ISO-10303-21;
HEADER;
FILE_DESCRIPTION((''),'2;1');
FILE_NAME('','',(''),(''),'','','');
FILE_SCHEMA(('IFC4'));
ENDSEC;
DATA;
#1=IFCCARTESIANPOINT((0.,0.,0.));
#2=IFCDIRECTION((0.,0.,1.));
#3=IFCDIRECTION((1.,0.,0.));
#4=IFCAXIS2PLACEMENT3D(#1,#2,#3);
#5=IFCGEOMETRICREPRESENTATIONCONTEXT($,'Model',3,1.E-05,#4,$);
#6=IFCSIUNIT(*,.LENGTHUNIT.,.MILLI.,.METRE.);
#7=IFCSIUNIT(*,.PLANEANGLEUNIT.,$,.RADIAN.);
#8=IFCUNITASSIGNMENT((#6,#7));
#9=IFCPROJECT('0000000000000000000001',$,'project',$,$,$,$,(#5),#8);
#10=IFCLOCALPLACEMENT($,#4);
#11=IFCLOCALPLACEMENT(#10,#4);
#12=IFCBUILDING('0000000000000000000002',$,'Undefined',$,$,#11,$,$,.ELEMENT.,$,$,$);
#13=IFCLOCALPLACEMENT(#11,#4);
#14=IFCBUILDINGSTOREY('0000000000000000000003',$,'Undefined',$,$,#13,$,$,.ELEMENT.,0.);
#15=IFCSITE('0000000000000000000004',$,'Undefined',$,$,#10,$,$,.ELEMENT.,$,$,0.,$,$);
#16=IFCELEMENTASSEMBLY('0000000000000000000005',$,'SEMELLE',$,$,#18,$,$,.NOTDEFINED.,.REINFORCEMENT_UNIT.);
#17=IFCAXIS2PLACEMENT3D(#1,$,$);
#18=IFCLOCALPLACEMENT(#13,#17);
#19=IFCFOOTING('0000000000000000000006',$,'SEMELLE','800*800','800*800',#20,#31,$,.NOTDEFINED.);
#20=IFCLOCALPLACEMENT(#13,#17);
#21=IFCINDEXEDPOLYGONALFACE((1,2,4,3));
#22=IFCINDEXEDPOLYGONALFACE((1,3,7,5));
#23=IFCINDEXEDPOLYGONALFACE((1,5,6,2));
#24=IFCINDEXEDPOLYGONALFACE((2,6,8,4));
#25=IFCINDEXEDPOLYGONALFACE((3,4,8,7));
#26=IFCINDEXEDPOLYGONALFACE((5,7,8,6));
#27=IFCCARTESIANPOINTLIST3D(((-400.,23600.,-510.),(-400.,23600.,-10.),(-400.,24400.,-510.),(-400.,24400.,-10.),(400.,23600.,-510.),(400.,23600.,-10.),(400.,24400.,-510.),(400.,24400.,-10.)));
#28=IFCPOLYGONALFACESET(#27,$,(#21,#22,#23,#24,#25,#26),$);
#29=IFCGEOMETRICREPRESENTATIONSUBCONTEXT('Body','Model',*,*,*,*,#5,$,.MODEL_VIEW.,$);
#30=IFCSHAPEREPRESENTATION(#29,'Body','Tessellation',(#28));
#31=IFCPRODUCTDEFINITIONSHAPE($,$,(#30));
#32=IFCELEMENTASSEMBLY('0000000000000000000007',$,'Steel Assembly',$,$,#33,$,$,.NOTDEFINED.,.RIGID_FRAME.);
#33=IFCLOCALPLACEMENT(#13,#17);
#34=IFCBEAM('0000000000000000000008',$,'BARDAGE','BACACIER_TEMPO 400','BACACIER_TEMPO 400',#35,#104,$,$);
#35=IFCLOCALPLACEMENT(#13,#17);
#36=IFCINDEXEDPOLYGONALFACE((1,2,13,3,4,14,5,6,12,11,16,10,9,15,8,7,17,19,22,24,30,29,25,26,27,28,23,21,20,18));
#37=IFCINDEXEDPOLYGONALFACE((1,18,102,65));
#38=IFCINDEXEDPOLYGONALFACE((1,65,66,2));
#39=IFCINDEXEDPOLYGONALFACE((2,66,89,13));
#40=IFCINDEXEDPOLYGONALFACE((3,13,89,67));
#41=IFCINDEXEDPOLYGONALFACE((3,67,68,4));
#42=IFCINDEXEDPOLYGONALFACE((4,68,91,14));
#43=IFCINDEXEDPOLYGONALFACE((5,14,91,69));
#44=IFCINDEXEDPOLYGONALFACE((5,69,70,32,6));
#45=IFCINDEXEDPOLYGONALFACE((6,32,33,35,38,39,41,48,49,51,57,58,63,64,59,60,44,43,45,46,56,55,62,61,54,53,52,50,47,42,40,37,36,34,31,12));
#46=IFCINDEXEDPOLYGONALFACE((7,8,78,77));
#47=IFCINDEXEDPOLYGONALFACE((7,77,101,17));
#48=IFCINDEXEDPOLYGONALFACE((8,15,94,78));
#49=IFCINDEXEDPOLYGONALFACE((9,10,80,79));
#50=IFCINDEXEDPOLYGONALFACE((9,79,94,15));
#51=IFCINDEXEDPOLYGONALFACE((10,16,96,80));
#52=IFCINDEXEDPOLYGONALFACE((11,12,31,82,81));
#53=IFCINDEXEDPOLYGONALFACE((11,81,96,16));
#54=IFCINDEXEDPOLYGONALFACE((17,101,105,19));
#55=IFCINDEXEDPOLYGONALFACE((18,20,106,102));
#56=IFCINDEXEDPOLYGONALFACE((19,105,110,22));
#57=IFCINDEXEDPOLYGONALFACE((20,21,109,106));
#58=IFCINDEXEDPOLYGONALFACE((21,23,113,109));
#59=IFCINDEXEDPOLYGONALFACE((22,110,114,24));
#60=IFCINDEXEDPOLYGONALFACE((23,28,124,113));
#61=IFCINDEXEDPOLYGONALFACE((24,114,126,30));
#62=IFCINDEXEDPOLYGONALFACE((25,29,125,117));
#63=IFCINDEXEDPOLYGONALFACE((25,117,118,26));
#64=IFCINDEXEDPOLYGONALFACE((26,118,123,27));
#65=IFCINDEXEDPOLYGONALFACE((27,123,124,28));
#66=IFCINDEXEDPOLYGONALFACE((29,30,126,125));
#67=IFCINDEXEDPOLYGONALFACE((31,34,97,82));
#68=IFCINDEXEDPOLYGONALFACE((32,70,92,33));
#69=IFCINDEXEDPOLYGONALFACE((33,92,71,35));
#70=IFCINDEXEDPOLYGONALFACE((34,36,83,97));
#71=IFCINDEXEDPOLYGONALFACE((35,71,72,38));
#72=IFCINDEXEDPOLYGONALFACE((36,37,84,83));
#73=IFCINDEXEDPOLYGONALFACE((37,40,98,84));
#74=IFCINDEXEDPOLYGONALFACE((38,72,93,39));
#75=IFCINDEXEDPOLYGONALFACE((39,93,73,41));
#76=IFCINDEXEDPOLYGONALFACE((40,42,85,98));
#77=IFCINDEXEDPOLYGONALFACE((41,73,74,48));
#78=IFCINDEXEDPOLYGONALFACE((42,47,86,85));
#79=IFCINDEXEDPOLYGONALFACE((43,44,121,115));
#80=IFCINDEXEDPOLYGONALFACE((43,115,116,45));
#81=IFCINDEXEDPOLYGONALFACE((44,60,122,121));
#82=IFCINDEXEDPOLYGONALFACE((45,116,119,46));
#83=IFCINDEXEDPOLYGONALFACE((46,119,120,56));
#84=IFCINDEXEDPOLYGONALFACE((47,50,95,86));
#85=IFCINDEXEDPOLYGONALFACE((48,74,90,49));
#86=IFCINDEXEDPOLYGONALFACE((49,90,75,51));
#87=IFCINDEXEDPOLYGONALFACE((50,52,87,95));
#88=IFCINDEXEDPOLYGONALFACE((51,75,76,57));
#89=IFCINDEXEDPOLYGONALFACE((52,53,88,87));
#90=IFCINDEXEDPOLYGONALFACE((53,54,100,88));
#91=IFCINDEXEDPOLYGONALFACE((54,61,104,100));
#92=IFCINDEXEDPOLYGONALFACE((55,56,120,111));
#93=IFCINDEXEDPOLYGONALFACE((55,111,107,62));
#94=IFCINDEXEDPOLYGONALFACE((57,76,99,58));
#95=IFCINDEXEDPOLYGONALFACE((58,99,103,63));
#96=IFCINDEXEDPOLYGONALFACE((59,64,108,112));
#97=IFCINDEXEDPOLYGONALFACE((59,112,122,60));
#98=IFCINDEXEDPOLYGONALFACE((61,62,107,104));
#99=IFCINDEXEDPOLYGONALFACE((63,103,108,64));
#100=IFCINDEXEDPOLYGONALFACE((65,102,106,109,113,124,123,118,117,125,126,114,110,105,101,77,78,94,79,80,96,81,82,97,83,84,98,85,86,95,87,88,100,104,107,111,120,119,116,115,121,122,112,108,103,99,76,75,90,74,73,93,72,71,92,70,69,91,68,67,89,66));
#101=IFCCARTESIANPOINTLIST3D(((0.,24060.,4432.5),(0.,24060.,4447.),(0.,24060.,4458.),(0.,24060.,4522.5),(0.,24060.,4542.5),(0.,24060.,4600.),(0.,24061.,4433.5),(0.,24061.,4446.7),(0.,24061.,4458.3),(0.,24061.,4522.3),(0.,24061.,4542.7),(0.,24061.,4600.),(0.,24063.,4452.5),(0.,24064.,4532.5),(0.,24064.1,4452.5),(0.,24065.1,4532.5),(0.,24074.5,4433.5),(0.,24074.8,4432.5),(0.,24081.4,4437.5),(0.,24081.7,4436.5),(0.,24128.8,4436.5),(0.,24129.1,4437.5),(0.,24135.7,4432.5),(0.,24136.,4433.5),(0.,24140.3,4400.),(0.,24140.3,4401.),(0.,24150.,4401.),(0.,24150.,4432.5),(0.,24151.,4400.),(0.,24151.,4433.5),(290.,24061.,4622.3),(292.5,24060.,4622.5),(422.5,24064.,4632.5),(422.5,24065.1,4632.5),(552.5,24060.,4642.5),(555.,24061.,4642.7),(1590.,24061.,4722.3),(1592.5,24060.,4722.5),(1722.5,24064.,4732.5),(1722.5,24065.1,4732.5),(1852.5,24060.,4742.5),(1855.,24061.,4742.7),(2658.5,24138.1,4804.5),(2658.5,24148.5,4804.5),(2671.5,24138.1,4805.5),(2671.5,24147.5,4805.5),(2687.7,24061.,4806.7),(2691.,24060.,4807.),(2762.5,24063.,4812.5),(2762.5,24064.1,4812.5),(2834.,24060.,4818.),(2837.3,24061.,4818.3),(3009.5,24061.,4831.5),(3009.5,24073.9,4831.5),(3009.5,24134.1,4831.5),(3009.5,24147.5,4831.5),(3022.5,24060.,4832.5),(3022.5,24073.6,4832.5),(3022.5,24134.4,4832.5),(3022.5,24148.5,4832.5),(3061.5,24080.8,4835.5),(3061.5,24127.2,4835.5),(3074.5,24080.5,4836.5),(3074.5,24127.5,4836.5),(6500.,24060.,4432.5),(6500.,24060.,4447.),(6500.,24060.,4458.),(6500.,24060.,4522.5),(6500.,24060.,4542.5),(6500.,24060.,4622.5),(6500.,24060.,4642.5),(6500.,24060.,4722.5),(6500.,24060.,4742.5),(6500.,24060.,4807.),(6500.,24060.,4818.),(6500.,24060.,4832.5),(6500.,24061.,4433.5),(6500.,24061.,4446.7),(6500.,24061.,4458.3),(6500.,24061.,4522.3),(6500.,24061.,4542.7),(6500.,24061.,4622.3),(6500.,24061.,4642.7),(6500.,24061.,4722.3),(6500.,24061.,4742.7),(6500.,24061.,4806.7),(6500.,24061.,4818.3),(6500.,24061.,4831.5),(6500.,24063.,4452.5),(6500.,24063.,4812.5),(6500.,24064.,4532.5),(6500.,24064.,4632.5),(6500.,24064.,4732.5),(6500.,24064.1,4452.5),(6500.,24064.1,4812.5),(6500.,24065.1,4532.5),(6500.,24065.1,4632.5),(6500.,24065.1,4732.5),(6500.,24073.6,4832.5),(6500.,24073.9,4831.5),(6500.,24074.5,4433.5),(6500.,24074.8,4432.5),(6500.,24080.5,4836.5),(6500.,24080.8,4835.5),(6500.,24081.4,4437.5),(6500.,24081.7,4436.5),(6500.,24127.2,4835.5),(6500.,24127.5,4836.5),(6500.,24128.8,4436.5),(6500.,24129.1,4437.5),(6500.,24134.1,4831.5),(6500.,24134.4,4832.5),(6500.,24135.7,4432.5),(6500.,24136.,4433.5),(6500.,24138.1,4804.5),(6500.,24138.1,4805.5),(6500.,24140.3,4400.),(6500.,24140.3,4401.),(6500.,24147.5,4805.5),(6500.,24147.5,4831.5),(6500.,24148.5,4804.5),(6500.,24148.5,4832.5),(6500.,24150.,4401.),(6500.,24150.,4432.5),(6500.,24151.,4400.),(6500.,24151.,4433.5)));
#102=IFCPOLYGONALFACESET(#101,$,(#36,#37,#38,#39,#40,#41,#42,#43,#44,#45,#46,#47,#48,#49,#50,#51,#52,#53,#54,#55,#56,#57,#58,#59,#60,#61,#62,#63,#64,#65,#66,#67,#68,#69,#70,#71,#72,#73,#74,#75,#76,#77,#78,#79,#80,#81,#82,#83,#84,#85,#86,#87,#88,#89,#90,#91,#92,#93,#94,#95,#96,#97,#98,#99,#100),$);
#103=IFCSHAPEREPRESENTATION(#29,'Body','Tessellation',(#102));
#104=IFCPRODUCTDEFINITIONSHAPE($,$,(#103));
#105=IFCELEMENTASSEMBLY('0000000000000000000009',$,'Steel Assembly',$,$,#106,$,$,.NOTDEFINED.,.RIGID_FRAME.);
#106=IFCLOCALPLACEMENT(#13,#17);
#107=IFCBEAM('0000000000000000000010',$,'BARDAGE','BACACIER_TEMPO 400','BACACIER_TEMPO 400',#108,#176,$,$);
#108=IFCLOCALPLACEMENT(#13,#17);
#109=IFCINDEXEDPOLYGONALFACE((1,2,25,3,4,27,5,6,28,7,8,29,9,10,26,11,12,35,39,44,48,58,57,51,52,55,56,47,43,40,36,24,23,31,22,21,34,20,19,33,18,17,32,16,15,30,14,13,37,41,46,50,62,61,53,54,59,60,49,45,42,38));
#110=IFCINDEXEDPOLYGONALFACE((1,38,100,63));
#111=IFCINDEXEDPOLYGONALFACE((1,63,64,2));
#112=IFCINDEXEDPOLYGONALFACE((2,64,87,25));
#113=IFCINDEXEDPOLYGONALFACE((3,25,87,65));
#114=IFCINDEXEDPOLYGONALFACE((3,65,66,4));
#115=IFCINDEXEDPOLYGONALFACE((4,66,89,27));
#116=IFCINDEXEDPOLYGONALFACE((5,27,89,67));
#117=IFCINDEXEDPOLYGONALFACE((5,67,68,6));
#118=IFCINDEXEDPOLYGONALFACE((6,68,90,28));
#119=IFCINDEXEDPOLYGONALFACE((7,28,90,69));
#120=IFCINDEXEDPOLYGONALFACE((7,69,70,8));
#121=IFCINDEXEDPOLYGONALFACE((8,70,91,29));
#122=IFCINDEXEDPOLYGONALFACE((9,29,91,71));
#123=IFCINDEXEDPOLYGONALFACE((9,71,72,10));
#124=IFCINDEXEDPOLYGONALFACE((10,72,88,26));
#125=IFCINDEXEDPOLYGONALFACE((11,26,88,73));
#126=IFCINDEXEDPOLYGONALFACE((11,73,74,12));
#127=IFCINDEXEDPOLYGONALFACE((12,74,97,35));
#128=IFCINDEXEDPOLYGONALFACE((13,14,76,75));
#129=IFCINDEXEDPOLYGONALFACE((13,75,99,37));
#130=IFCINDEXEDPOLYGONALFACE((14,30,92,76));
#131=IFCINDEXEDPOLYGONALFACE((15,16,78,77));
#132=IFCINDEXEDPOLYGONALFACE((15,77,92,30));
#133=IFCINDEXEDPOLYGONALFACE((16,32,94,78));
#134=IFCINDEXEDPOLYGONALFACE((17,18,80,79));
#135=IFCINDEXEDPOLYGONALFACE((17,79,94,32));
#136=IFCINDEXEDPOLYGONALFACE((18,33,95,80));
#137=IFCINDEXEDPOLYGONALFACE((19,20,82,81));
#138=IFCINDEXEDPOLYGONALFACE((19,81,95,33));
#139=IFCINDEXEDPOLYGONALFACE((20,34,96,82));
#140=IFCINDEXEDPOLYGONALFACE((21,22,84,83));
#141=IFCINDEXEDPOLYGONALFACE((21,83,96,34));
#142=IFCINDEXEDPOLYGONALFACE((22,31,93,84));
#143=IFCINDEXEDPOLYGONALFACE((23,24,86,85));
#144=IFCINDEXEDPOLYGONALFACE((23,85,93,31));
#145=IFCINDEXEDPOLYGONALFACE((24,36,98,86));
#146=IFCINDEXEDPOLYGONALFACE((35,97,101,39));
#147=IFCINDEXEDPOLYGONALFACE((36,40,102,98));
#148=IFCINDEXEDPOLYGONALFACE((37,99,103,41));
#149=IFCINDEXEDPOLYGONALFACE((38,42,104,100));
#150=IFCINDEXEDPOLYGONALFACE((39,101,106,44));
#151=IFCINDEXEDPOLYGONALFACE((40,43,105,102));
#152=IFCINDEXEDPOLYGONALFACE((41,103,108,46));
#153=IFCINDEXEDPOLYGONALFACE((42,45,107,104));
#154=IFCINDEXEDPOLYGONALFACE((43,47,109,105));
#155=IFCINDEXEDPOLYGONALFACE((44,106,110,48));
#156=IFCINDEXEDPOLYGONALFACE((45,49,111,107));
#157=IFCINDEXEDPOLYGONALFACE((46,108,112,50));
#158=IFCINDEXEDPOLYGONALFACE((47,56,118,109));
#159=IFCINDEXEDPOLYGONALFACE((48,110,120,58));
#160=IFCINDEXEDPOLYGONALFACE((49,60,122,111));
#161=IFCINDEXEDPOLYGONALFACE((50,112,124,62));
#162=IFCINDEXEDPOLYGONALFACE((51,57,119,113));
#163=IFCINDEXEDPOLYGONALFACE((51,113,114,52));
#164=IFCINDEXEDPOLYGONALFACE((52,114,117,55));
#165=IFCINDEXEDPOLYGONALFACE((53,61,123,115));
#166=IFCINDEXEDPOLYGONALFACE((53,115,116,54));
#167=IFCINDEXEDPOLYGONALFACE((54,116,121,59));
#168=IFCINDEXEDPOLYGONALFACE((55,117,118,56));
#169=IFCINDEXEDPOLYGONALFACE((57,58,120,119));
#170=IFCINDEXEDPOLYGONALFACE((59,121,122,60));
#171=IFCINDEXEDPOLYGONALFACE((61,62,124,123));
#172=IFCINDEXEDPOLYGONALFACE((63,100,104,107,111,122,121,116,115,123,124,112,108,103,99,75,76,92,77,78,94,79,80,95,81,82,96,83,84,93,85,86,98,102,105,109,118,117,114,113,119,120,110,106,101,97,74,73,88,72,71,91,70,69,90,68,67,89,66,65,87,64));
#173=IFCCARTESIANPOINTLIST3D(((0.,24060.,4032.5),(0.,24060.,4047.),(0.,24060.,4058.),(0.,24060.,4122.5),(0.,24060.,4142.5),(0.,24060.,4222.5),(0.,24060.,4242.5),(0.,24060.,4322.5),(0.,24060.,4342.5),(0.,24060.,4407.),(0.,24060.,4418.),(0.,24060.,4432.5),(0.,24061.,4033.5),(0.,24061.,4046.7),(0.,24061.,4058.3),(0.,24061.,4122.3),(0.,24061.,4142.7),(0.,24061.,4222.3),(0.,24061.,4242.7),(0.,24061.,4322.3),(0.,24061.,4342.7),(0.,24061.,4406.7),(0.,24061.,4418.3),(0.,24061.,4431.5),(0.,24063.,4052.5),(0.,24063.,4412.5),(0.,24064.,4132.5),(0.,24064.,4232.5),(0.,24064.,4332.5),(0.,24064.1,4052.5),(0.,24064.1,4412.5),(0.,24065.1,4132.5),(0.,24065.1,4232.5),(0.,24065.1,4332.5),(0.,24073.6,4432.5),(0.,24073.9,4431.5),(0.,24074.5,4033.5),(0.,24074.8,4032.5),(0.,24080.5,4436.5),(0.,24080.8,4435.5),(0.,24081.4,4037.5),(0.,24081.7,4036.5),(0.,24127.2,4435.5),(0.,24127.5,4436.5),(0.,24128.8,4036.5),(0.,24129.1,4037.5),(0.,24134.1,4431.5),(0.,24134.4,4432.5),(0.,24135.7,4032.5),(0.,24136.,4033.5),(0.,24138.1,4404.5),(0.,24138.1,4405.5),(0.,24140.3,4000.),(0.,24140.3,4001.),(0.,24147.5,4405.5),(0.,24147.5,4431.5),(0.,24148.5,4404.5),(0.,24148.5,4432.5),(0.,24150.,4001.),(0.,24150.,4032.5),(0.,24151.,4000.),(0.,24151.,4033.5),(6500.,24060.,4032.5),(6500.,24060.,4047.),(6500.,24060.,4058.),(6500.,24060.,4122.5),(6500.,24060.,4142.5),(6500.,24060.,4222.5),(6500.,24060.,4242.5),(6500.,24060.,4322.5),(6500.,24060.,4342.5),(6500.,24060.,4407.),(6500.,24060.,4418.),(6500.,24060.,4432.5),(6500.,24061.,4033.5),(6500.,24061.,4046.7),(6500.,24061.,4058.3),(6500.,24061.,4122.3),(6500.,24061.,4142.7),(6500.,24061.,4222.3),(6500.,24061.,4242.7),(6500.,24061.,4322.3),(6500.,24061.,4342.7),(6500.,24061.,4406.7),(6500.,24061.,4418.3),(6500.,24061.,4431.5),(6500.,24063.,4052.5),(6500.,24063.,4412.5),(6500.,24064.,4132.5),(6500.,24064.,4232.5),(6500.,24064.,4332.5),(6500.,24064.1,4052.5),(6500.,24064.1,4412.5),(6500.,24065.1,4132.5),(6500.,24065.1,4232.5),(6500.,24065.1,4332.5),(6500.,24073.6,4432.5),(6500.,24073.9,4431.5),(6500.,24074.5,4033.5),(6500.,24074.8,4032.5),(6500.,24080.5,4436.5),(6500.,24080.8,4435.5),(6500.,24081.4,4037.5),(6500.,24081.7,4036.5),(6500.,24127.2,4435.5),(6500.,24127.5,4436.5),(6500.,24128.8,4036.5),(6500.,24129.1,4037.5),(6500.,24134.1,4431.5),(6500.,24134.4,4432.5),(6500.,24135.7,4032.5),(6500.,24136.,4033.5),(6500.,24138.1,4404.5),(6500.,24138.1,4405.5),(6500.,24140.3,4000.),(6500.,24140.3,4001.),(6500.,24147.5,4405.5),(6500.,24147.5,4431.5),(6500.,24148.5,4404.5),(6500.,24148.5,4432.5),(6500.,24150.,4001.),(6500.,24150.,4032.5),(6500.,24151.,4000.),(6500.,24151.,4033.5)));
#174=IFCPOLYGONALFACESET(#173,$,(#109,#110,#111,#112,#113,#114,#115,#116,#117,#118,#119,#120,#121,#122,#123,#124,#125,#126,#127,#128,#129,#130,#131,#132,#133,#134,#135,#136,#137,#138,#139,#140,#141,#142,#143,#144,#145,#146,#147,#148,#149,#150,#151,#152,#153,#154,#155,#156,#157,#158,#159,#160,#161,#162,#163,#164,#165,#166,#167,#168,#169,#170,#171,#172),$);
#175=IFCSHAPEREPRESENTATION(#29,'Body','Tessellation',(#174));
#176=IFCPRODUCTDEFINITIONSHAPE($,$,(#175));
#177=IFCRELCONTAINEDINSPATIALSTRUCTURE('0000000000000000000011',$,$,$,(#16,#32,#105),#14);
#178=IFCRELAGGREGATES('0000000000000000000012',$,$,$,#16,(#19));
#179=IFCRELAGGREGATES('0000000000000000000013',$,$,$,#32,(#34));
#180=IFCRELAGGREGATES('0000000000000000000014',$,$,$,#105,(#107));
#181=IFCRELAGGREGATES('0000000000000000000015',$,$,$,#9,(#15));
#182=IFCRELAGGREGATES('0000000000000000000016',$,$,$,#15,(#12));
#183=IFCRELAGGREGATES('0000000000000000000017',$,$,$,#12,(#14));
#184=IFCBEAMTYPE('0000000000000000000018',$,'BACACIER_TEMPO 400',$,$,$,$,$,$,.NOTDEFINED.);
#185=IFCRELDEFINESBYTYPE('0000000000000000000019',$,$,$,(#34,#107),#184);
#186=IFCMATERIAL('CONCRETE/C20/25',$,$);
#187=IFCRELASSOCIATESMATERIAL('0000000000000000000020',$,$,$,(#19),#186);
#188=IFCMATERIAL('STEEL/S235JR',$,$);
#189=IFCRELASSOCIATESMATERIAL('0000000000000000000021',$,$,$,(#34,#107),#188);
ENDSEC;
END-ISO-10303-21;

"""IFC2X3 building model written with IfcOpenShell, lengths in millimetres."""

from ifc_helpers import new_model, si_unit, frame, origin_with_axes, origin_2d_with_axis, place, context, subcontext, project, spatial, polyline, rectangle, outline, extrude, clip, halfspace, material, type_object, element, aggregate, save


model = new_model("IFC2X3")

# Units and contexts
model_context = context("Model", 3, precision=1e-05, world=origin_with_axes())
body_context = subcontext(model_context, "Body", "Model", "MODEL_VIEW")
ifc_project = project(units=[si_unit("LENGTHUNIT", "METRE", prefix="MILLI"), si_unit("PLANEANGLEUNIT", "RADIAN")], contexts=[model_context])

# Site, building, storey
site_placement = place(None, origin_with_axes())
site = spatial("IfcSite", under=ifc_project, at=site_placement, Name="Undefined", CompositionType="ELEMENT", RefElevation=0.0)
building_placement = place(site_placement, origin_with_axes())
building = spatial("IfcBuilding", under=site, at=building_placement, Name="Undefined", CompositionType="ELEMENT")
storey_placement = place(building_placement, origin_with_axes())
storey = spatial("IfcBuildingStorey", under=building, at=storey_placement, Name="Undefined", CompositionType="ELEMENT", Elevation=0.0)

# Element assembly, footing
assembly_1_placement = place(storey_placement, origin_with_axes())
assembly_1 = element("IfcElementAssembly", 1, at=assembly_1_placement, inside=storey, Name="SEMELLE", AssemblyPlace="NOTDEFINED", PredefinedType="REINFORCEMENT_UNIT")
ifc_material_1 = material(Name="CONCRETE/C20/25")
footing_placement = place(assembly_1_placement, frame((0.0, 24000.0, -510.0), z_axis=(0.0, -1.0, 0.0), x_axis=(0.0, 0.0, 1.0)))
footing = element("IfcFooting", 2, at=footing_placement, material=ifc_material_1, Name="SEMELLE", Description="800*800", ObjectType="800*800", PredefinedType="NOTDEFINED", context=body_context, shape_type="SweptSolid", body=[
    extrude(rectangle(XDim=800.0, YDim=800.0, at=origin_2d_with_axis()), frame((500.0, 0.0, 0.0), z_axis=(-1.0, 0.0, 0.0), x_axis=(0.0, -1.0, 0.0)), (0.0, 0.0, 1.0), 500.0),
])
aggregate(assembly_1, [footing])

# Element assemblies, beams
ifc_material_2 = material(Name="STEEL/S235JR")
beam_type_1 = type_object("IfcBeamType", Name="BACACIER_TEMPO 400", PredefinedType="NOTDEFINED")
assembly_2_placement = place(storey_placement, origin_with_axes())
assembly_2 = element("IfcElementAssembly", 3, at=assembly_2_placement, inside=storey, Name="Steel Assembly", AssemblyPlace="NOTDEFINED", PredefinedType="RIGID_FRAME")
beam_1_placement = place(assembly_2_placement, frame((0.0, 24105.5, 4618.2), z_axis=(0.0, 1.0, 0.0), x_axis=(1.0, 0.0, 0.0)))
beam_1 = element("IfcBeam", 4, at=beam_1_placement, type_object=beam_type_1, material=ifc_material_2, Name="BARDAGE", Description="BACACIER_TEMPO 400", ObjectType="BACACIER_TEMPO 400", context=body_context, shape_type="Clipping", body=[
    clip(extrude(outline(polyline([(218.2, -25.0), (214.2, -31.9), (214.2, -45.5), (199.8, -45.5), (194.2, -42.5), (188.8, -45.5), (124.2, -45.5), (114.2, -41.5), (104.2, -45.5), (24.2, -45.5), (14.2, -41.5), (4.2, -45.5), (-75.8, -45.5), (-85.8, -41.5), (-95.8, -45.5), (-160.2, -45.5), (-165.8, -42.5), (-171.2, -45.5), (-185.8, -45.5), (-185.8, -30.7), (-181.8, -23.8), (-181.8, 23.3), (-185.8, 30.2), (-185.8, 44.5), (-217.2, 44.5), (-217.2, 34.8), (-218.2, 34.8), (-218.2, 45.5), (-184.8, 45.5), (-184.8, 30.5), (-180.8, 23.6), (-180.8, -24.1), (-184.8, -31.0), (-184.8, -44.5), (-171.5, -44.5), (-165.8, -41.4), (-160.0, -44.5), (-95.9, -44.5), (-85.8, -40.4), (-75.6, -44.5), (4.1, -44.5), (14.2, -40.4), (24.4, -44.5), (104.1, -44.5), (114.2, -40.4), (124.4, -44.5), (188.5, -44.5), (194.2, -41.4), (200.0, -44.5), (213.2, -44.5), (213.2, -31.6), (217.2, -24.7), (217.2, 21.7), (213.2, 28.6), (213.2, 42.0), (187.2, 42.0), (187.2, 32.5), (186.2, 32.5), (186.2, 43.0), (214.2, 43.0), (214.2, 28.9), (218.2, 22.0), (218.2, -25.0)])), frame((6500.0, 0.0, 0.0), z_axis=(-1.0, 0.0, 0.0), x_axis=(0.0, -1.0, 0.0)), (0.0, 0.0, 1.0), 6500.0), halfspace(frame((0.0, 18.3, -45.0), z_axis=(-0.076696, -0.997054, 0.0), x_axis=(0.0, 0.0, 1.0)), False)),
])
aggregate(assembly_2, [beam_1])
assembly_3_placement = place(storey_placement, origin_with_axes())
assembly_3 = element("IfcElementAssembly", 5, at=assembly_3_placement, inside=storey, Name="Steel Assembly", AssemblyPlace="NOTDEFINED", PredefinedType="RIGID_FRAME")
beam_2_placement = place(assembly_3_placement, frame((0.0, 24105.5, 4218.2), z_axis=(0.0, 1.0, 0.0), x_axis=(1.0, 0.0, 0.0)))
beam_2 = element("IfcBeam", 6, at=beam_2_placement, type_object=beam_type_1, material=ifc_material_2, Name="BARDAGE", Description="BACACIER_TEMPO 400", ObjectType="BACACIER_TEMPO 400", context=body_context, shape_type="SweptSolid", body=[
    extrude(outline(polyline([(218.2, -25.0), (214.2, -31.9), (214.2, -45.5), (199.8, -45.5), (194.2, -42.5), (188.8, -45.5), (124.2, -45.5), (114.2, -41.5), (104.2, -45.5), (24.2, -45.5), (14.2, -41.5), (4.2, -45.5), (-75.8, -45.5), (-85.8, -41.5), (-95.8, -45.5), (-160.2, -45.5), (-165.8, -42.5), (-171.2, -45.5), (-185.8, -45.5), (-185.8, -30.7), (-181.8, -23.8), (-181.8, 23.3), (-185.8, 30.2), (-185.8, 44.5), (-217.2, 44.5), (-217.2, 34.8), (-218.2, 34.8), (-218.2, 45.5), (-184.8, 45.5), (-184.8, 30.5), (-180.8, 23.6), (-180.8, -24.1), (-184.8, -31.0), (-184.8, -44.5), (-171.5, -44.5), (-165.8, -41.4), (-160.0, -44.5), (-95.9, -44.5), (-85.8, -40.4), (-75.6, -44.5), (4.1, -44.5), (14.2, -40.4), (24.4, -44.5), (104.1, -44.5), (114.2, -40.4), (124.4, -44.5), (188.5, -44.5), (194.2, -41.4), (200.0, -44.5), (213.2, -44.5), (213.2, -31.6), (217.2, -24.7), (217.2, 21.7), (213.2, 28.6), (213.2, 42.0), (187.2, 42.0), (187.2, 32.5), (186.2, 32.5), (186.2, 43.0), (214.2, 43.0), (214.2, 28.9), (218.2, 22.0), (218.2, -25.0)])), frame((6500.0, 0.0, 0.0), z_axis=(-1.0, 0.0, 0.0), x_axis=(0.0, -1.0, 0.0)), (0.0, 0.0, 1.0), 6500.0),
])
aggregate(assembly_3, [beam_2])

save(model, "model.ifc")
